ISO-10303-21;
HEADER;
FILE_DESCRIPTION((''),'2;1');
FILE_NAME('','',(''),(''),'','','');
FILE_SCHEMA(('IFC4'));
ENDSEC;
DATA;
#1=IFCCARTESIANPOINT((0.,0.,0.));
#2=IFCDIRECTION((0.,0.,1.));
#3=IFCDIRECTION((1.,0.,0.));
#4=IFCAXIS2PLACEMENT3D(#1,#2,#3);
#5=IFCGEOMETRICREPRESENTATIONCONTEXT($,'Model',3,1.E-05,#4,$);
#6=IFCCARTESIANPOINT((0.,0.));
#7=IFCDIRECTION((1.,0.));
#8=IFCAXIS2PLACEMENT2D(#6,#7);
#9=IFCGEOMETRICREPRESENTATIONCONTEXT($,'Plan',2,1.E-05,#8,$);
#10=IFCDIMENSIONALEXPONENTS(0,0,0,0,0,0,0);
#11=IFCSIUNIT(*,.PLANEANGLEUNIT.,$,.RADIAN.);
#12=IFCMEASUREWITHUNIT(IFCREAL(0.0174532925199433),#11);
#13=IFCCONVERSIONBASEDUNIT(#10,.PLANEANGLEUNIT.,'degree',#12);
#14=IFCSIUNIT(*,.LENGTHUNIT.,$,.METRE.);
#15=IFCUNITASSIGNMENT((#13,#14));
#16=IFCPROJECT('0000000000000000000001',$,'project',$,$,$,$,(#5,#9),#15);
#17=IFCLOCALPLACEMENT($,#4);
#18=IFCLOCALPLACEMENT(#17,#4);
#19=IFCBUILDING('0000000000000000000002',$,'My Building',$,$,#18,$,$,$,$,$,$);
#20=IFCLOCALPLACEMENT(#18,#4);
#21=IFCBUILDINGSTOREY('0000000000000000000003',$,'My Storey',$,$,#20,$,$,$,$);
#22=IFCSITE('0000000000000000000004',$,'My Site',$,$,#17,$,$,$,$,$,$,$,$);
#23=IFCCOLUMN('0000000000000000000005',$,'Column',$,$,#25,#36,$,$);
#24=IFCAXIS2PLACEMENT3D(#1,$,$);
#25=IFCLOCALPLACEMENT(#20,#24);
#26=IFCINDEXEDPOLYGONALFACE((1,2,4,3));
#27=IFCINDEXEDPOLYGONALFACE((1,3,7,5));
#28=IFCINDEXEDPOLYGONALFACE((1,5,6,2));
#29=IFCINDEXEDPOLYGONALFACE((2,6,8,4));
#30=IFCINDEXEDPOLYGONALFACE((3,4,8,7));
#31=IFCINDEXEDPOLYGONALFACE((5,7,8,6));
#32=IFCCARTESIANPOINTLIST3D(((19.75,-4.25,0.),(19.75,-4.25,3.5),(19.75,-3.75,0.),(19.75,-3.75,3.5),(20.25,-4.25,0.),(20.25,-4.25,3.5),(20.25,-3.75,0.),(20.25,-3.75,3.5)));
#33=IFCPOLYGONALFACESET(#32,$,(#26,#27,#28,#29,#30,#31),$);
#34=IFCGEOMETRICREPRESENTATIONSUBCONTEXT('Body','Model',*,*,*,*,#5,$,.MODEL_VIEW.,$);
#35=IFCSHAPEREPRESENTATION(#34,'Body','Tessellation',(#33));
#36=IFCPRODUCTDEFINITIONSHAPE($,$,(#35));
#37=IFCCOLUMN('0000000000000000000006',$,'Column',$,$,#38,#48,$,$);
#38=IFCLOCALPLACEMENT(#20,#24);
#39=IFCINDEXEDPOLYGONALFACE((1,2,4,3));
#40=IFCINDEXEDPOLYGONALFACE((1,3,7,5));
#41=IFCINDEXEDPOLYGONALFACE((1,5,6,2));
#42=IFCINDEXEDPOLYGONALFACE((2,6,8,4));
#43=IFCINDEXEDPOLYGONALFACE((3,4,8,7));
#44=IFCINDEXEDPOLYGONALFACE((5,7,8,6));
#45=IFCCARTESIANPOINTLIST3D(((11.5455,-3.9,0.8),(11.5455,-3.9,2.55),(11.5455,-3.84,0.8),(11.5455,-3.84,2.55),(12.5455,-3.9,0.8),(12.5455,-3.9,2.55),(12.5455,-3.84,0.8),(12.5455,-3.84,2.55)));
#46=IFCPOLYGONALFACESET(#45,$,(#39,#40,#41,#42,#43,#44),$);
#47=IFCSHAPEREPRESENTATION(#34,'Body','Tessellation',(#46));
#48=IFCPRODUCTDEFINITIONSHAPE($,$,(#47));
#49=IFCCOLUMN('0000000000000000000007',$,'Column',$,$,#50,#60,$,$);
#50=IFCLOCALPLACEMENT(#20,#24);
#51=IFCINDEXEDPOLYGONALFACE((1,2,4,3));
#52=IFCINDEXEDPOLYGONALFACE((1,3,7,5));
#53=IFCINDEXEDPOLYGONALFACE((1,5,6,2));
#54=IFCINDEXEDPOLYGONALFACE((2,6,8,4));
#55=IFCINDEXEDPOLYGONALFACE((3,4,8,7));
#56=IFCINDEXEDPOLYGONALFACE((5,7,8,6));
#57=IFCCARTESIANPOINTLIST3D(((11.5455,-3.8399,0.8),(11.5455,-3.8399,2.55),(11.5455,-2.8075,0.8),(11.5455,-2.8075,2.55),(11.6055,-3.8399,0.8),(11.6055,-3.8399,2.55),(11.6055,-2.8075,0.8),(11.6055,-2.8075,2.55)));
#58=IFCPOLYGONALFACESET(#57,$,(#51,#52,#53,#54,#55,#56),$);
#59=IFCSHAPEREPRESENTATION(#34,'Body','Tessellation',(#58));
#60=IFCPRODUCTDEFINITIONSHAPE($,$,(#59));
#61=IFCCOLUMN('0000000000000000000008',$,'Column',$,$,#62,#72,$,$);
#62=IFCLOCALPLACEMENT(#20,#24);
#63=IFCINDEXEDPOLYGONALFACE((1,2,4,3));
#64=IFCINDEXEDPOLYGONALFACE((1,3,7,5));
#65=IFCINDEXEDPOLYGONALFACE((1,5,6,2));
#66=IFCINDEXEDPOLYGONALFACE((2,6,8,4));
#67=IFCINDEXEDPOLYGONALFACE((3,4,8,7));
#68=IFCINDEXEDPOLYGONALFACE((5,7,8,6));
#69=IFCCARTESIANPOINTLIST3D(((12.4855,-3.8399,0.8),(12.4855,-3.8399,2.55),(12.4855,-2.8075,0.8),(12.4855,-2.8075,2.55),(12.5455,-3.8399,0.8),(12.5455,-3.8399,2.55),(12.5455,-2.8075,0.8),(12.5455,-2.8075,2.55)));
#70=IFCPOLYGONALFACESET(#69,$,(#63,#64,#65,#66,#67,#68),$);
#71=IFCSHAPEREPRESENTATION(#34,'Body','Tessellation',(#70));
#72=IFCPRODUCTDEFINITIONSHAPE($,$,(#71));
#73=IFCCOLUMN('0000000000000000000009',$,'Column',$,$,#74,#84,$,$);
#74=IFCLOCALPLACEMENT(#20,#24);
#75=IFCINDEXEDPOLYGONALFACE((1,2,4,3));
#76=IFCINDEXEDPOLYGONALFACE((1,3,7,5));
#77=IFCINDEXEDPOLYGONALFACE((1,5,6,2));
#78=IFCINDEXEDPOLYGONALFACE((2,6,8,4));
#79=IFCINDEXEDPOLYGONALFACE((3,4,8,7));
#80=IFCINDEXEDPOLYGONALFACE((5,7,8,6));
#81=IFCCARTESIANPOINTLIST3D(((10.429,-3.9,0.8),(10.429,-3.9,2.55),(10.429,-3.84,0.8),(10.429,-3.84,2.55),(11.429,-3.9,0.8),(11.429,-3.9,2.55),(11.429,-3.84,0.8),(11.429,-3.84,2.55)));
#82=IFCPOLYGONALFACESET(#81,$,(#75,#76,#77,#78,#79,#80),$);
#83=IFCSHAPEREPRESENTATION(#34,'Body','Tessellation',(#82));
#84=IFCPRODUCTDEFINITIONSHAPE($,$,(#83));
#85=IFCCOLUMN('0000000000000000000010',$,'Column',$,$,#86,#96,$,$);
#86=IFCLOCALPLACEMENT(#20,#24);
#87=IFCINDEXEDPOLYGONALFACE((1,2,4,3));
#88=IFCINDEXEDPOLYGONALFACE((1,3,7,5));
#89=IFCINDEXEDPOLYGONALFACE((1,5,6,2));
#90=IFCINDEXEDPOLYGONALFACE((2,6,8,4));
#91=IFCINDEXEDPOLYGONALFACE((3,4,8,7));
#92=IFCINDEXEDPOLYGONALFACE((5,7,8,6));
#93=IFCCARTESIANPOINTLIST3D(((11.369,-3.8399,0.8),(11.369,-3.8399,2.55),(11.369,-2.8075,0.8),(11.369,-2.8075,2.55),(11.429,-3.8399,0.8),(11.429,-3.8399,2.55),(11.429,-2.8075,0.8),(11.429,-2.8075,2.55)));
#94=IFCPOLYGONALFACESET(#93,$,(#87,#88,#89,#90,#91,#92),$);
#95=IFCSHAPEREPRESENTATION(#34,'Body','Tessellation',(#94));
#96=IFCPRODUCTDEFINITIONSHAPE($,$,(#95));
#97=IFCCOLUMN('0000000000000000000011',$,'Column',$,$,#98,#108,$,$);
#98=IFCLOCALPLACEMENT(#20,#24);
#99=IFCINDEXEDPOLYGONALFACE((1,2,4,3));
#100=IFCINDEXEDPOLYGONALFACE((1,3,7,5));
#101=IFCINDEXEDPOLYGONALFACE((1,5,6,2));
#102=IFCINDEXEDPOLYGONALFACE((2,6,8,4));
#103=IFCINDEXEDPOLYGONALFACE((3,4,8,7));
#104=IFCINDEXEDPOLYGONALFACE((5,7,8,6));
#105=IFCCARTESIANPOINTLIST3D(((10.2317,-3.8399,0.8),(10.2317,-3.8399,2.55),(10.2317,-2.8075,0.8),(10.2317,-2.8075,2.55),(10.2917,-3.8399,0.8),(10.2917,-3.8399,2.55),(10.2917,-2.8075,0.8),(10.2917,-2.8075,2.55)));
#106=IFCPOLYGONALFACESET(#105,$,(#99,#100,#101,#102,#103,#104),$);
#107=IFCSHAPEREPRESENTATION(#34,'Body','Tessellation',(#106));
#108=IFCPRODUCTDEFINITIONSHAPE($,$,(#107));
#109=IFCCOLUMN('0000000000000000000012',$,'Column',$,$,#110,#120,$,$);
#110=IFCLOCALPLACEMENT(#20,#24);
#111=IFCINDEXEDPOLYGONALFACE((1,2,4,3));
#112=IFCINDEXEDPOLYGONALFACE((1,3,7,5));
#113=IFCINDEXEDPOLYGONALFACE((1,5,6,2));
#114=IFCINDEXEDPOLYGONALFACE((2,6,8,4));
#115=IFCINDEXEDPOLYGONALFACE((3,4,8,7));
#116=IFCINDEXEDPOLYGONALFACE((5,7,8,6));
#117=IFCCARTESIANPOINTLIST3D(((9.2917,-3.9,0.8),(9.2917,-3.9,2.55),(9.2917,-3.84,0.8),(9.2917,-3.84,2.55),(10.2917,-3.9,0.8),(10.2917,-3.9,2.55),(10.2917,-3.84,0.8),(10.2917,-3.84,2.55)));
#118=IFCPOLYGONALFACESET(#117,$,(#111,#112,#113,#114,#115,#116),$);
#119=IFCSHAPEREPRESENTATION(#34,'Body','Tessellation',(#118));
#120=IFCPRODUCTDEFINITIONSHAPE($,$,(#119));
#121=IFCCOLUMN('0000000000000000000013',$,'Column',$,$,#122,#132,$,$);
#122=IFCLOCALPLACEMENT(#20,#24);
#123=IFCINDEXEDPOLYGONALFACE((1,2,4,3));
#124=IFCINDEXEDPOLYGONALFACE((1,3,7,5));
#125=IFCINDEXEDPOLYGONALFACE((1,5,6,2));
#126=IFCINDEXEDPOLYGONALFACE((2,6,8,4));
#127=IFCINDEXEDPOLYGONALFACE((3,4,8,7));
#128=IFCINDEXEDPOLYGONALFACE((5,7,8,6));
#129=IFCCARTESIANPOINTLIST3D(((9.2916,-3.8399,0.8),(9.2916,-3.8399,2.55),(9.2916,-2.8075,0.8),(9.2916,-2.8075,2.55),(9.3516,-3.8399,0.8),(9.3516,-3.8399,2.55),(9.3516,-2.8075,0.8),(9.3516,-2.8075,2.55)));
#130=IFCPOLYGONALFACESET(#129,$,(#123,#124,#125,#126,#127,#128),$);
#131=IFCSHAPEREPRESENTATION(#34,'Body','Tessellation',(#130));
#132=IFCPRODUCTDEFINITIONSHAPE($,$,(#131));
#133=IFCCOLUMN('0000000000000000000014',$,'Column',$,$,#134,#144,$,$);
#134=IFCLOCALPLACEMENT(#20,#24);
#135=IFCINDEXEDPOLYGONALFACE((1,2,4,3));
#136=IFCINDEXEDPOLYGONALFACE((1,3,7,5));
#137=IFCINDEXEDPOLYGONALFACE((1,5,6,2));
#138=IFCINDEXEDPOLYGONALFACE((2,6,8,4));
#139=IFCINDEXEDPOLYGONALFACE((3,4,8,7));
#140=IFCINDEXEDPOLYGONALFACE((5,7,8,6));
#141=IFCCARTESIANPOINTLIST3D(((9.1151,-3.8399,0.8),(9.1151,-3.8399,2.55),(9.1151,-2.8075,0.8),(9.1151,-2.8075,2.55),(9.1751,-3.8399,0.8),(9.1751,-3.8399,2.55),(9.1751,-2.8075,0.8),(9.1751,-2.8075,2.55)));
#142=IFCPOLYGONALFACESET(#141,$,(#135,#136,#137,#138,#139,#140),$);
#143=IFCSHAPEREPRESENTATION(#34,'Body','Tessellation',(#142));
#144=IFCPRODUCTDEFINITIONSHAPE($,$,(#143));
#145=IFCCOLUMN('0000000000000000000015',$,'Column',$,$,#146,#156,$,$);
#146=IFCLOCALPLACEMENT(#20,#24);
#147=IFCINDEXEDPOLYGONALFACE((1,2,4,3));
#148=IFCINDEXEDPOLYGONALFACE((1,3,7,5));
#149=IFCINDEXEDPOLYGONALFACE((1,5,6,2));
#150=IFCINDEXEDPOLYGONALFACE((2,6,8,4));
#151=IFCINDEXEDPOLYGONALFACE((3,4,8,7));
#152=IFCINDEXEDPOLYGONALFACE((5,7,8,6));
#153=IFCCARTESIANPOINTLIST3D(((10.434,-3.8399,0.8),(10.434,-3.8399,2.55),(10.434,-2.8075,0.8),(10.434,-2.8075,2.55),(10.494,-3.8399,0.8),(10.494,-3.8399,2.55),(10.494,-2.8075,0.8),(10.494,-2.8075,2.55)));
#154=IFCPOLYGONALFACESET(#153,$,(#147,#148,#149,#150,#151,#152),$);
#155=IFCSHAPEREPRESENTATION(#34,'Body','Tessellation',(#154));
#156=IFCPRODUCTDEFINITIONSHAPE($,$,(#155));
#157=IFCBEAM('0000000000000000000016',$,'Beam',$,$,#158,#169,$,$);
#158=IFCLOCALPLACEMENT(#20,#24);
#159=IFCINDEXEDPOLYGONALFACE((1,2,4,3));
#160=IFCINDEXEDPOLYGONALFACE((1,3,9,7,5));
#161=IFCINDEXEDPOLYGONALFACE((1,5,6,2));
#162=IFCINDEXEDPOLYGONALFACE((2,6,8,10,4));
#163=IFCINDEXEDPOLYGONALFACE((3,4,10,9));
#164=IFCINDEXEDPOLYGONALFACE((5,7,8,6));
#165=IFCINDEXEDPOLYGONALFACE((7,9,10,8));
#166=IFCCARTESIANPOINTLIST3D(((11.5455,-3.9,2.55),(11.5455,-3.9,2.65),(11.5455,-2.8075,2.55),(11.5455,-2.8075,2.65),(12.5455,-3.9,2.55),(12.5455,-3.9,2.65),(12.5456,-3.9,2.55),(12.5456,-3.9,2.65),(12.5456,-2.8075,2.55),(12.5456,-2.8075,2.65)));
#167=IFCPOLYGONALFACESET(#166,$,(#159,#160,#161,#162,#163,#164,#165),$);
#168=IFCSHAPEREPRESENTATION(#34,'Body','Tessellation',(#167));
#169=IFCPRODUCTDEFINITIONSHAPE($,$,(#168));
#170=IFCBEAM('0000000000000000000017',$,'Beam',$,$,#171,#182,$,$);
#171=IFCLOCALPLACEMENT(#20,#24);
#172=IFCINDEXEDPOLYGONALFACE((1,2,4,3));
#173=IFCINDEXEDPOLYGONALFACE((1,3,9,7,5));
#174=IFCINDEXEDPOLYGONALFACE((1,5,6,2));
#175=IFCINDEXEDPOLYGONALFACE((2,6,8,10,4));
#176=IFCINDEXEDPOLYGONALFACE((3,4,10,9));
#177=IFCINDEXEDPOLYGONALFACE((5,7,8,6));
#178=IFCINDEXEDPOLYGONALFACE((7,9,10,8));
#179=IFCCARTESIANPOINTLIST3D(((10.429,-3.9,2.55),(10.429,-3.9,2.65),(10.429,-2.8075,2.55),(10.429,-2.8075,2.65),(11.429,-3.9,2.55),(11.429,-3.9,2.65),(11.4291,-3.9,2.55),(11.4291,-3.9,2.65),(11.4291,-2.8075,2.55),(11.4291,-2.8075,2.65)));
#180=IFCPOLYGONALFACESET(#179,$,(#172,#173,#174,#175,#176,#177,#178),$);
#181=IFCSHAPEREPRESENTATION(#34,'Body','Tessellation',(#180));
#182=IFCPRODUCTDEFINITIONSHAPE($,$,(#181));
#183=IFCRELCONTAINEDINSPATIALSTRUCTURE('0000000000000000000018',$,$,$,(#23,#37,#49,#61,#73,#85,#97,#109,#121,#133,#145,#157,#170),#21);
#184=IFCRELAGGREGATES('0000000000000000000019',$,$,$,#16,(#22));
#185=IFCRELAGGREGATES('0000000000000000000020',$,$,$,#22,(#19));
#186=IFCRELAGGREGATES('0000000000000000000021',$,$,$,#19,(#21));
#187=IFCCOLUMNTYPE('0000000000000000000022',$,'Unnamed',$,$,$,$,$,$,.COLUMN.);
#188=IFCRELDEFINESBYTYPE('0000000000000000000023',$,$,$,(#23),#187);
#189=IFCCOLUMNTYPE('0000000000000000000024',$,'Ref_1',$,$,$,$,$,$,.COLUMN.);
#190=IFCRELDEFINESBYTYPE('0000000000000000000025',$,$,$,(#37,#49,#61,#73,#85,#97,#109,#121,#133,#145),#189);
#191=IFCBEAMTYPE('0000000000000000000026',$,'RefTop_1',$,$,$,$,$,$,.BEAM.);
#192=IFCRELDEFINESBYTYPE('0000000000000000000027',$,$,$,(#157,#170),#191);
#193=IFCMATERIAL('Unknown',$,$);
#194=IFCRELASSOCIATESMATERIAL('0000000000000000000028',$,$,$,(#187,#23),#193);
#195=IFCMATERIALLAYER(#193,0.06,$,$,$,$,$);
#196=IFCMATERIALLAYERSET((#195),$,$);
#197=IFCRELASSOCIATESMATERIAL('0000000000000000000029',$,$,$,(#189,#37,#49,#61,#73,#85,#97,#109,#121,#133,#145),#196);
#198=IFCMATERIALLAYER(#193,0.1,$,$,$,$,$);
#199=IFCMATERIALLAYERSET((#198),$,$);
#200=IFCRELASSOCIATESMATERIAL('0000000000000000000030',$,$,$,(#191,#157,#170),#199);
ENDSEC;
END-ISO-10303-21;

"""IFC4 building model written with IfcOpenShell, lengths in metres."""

from ifc_helpers import new_model, entity, si_unit, converted_unit, frame, origin_with_axes, origin_2d_with_axis, place, context, subcontext, project, spatial, line, indexed_curve, rectangle, outline, extrude, material, layer, layer_set, layer_usage, material_profile, profile_set, profile_usage, type_object, element, save


model = new_model("IFC4")

# Units and contexts
model_context = context("Model", 3, precision=1e-05, world=origin_with_axes())
plan_context = context("Plan", 2, precision=1e-05, world=origin_2d_with_axis())
body_context_1 = subcontext(model_context, "Body", "Model", "MODEL_VIEW")
ifc_project = project(units=[converted_unit("PLANEANGLEUNIT", "degree", entity("IfcReal", 0.0174532925199433), si_unit("PLANEANGLEUNIT", "RADIAN"), dimensions=[0, 0, 0, 0, 0, 0, 0]), si_unit("LENGTHUNIT", "METRE")], contexts=[model_context, plan_context])

# Site, building, storey
site_placement = place(None, origin_with_axes())
site = spatial("IfcSite", under=ifc_project, at=site_placement, Name="My Site")
building_placement = place(site_placement, origin_with_axes())
building = spatial("IfcBuilding", under=site, at=building_placement, Name="My Building")
storey_placement = place(building_placement, origin_with_axes())
storey = spatial("IfcBuildingStorey", under=building, at=storey_placement, Name="My Storey")

# Columns
ifc_material = material(Name="Unknown")
ifc_material_profile = material_profile(ifc_material, rectangle(XDim=0.5, YDim=0.5))
ifc_profile_set = profile_set([ifc_material_profile])
ifc_profile_usage = profile_usage(ifc_profile_set, cardinal=5)
column_type_1 = type_object("IfcColumnType", Name="Unnamed", PredefinedType="COLUMN", material=ifc_profile_set)
column_1_placement = place(storey_placement, frame((20.0, -4.0, 0.0), z_axis=(0.0, 0.0, 1.0), x_axis=(1.0, 0.0, 0.0)))
element("IfcColumn", 1, at=column_1_placement, inside=storey, type_object=column_type_1, material=ifc_profile_usage, Name="Column", context=body_context_1, shape_type="SweptSolid", body=[
    extrude(rectangle(XDim=0.5, YDim=0.5), origin_with_axes(), (0.0, 0.0, 1.0), 3.5),
])
ifc_layer_1 = layer(ifc_material, 0.06)
ifc_layer_set_1 = layer_set([ifc_layer_1])
ifc_layer_usage_1 = layer_usage(ifc_layer_set_1, "AXIS2", "POSITIVE", 0.0)
column_type_2 = type_object("IfcColumnType", Name="Ref_1", PredefinedType="COLUMN", material=ifc_layer_set_1)
column_2_placement = place(storey_placement, frame((11.5455, -3.9, 0.8), z_axis=(0.0, 0.0, 1.0), x_axis=(1.0, 0.0, 0.0)))
element("IfcColumn", 2, at=column_2_placement, inside=storey, type_object=column_type_2, material=ifc_layer_usage_1, Name="Column", context=body_context_1, shape_type="SweptSolid", body=[
    extrude(outline(indexed_curve([(0.0, 0.0), (0.0, 0.06), (1.0, 0.06), (1.0, 0.0)], segments=[line(1, 2, 3, 4, 1)])), origin_with_axes(), (0.0, 0.0, 1.0), 1.75),
])
ifc_layer_usage_2 = layer_usage(ifc_layer_set_1, "AXIS2", "POSITIVE", 0.0)
column_3_placement = place(storey_placement, frame((11.5455, -2.8075, 0.8), z_axis=(0.0, 0.0, 1.0), x_axis=(0.0, -1.0, 0.0)))
element("IfcColumn", 3, at=column_3_placement, inside=storey, type_object=column_type_2, material=ifc_layer_usage_2, Name="Column", context=body_context_1, shape_type="SweptSolid", body=[
    extrude(outline(indexed_curve([(0.0, 0.0), (0.0, 0.06), (1.0325, 0.06), (1.0325, 0.0)], segments=[line(1, 2, 3, 4, 1)])), origin_with_axes(), (0.0, 0.0, 1.0), 1.75),
])
ifc_layer_usage_3 = layer_usage(ifc_layer_set_1, "AXIS2", "POSITIVE", 0.0)
column_4_placement = place(storey_placement, frame((12.4855, -2.8075, 0.8), z_axis=(0.0, 0.0, 1.0), x_axis=(0.0, -1.0, 0.0)))
element("IfcColumn", 4, at=column_4_placement, inside=storey, type_object=column_type_2, material=ifc_layer_usage_3, Name="Column", context=body_context_1, shape_type="SweptSolid", body=[
    extrude(outline(indexed_curve([(0.0, 0.0), (0.0, 0.06), (1.0325, 0.06), (1.0325, 0.0)], segments=[line(1, 2, 3, 4, 1)])), origin_with_axes(), (0.0, 0.0, 1.0), 1.75),
])
ifc_layer_usage_4 = layer_usage(ifc_layer_set_1, "AXIS2", "POSITIVE", 0.0)
column_5_placement = place(storey_placement, frame((10.429, -3.9, 0.8), z_axis=(0.0, 0.0, 1.0), x_axis=(1.0, 0.0, 0.0)))
element("IfcColumn", 5, at=column_5_placement, inside=storey, type_object=column_type_2, material=ifc_layer_usage_4, Name="Column", context=body_context_1, shape_type="SweptSolid", body=[
    extrude(outline(indexed_curve([(0.0, 0.0), (0.0, 0.06), (1.0, 0.06), (1.0, 0.0)], segments=[line(1, 2, 3, 4, 1)])), origin_with_axes(), (0.0, 0.0, 1.0), 1.75),
])
ifc_layer_usage_5 = layer_usage(ifc_layer_set_1, "AXIS2", "POSITIVE", 0.0)
column_6_placement = place(storey_placement, frame((11.369, -2.8075, 0.8), z_axis=(0.0, 0.0, 1.0), x_axis=(0.0, -1.0, 0.0)))
element("IfcColumn", 6, at=column_6_placement, inside=storey, type_object=column_type_2, material=ifc_layer_usage_5, Name="Column", context=body_context_1, shape_type="SweptSolid", body=[
    extrude(outline(indexed_curve([(0.0, 0.0), (0.0, 0.06), (1.0325, 0.06), (1.0325, 0.0)], segments=[line(1, 2, 3, 4, 1)])), origin_with_axes(), (0.0, 0.0, 1.0), 1.75),
])
ifc_layer_usage_6 = layer_usage(ifc_layer_set_1, "AXIS2", "POSITIVE", 0.0)
column_7_placement = place(storey_placement, frame((10.2317, -2.8075, 0.8), z_axis=(0.0, 0.0, 1.0), x_axis=(0.0, -1.0, 0.0)))
element("IfcColumn", 7, at=column_7_placement, inside=storey, type_object=column_type_2, material=ifc_layer_usage_6, Name="Column", context=body_context_1, shape_type="SweptSolid", body=[
    extrude(outline(indexed_curve([(0.0, 0.0), (0.0, 0.06), (1.0325, 0.06), (1.0325, 0.0)], segments=[line(1, 2, 3, 4, 1)])), origin_with_axes(), (0.0, 0.0, 1.0), 1.75),
])
ifc_layer_usage_7 = layer_usage(ifc_layer_set_1, "AXIS2", "POSITIVE", 0.0)
column_8_placement = place(storey_placement, frame((9.2917, -3.9, 0.8), z_axis=(0.0, 0.0, 1.0), x_axis=(1.0, 0.0, 0.0)))
element("IfcColumn", 8, at=column_8_placement, inside=storey, type_object=column_type_2, material=ifc_layer_usage_7, Name="Column", context=body_context_1, shape_type="SweptSolid", body=[
    extrude(outline(indexed_curve([(0.0, 0.0), (0.0, 0.06), (1.0, 0.06), (1.0, 0.0)], segments=[line(1, 2, 3, 4, 1)])), origin_with_axes(), (0.0, 0.0, 1.0), 1.75),
])
ifc_layer_usage_8 = layer_usage(ifc_layer_set_1, "AXIS2", "POSITIVE", 0.0)
column_9_placement = place(storey_placement, frame((9.2916, -2.8075, 0.8), z_axis=(0.0, 0.0, 1.0), x_axis=(0.0, -1.0, 0.0)))
element("IfcColumn", 9, at=column_9_placement, inside=storey, type_object=column_type_2, material=ifc_layer_usage_8, Name="Column", context=body_context_1, shape_type="SweptSolid", body=[
    extrude(outline(indexed_curve([(0.0, 0.0), (0.0, 0.06), (1.0325, 0.06), (1.0325, 0.0)], segments=[line(1, 2, 3, 4, 1)])), origin_with_axes(), (0.0, 0.0, 1.0), 1.75),
])
ifc_layer_usage_9 = layer_usage(ifc_layer_set_1, "AXIS2", "POSITIVE", 0.0)
column_10_placement = place(storey_placement, frame((9.1151, -2.8075, 0.8), z_axis=(0.0, 0.0, 1.0), x_axis=(0.0, -1.0, 0.0)))
element("IfcColumn", 10, at=column_10_placement, inside=storey, type_object=column_type_2, material=ifc_layer_usage_9, Name="Column", context=body_context_1, shape_type="SweptSolid", body=[
    extrude(outline(indexed_curve([(0.0, 0.0), (0.0, 0.06), (1.0325, 0.06), (1.0325, 0.0)], segments=[line(1, 2, 3, 4, 1)])), origin_with_axes(), (0.0, 0.0, 1.0), 1.75),
])
ifc_layer_usage_10 = layer_usage(ifc_layer_set_1, "AXIS2", "POSITIVE", 0.0)
column_11_placement = place(storey_placement, frame((10.434, -2.8075, 0.8), z_axis=(0.0, 0.0, 1.0), x_axis=(0.000001, -1.0, 0.0)))
element("IfcColumn", 11, at=column_11_placement, inside=storey, type_object=column_type_2, material=ifc_layer_usage_10, Name="Column", context=body_context_1, shape_type="SweptSolid", body=[
    extrude(outline(indexed_curve([(0.0, 0.0), (0.0, 0.06), (1.0325, 0.06), (1.0325, 0.0)], segments=[line(1, 2, 3, 4, 1)])), origin_with_axes(), (0.0, 0.0, 1.0), 1.75),
])

# Beams
ifc_layer_2 = layer(ifc_material, 0.1)
ifc_layer_set_2 = layer_set([ifc_layer_2])
ifc_layer_usage_11 = layer_usage(ifc_layer_set_2, "AXIS3", "POSITIVE", -0.1)
beam_type_1 = type_object("IfcBeamType", Name="RefTop_1", PredefinedType="BEAM", material=ifc_layer_set_2)
beam_1_placement = place(storey_placement, frame((12.5455, -3.9, 2.65), z_axis=(0.0, 0.0, 1.0), x_axis=(1.0, 0.0, 0.0)))
element("IfcBeam", 12, at=beam_1_placement, inside=storey, type_object=beam_type_1, material=ifc_layer_usage_11, Name="Beam", context=body_context_1, shape_type="SweptSolid", body=[
    extrude(outline(indexed_curve([(0.0, 0.0), (-1.0, 0.0), (-1.0, 1.0925), (0.0001, 1.0925), (0.0001, 0.0), (0.0, 0.0)])), frame((0.0, 0.0, -0.1), z_axis=(0.0, 0.0, 1.0), x_axis=(1.0, 0.0, 0.0)), (0.0, 0.0, 1.0), 0.1),
])
ifc_layer_usage_12 = layer_usage(ifc_layer_set_2, "AXIS3", "POSITIVE", -0.1)
beam_2_placement = place(storey_placement, frame((11.429, -3.9, 2.65), z_axis=(0.0, 0.0, 1.0), x_axis=(1.0, 0.0, 0.0)))
element("IfcBeam", 13, at=beam_2_placement, inside=storey, type_object=beam_type_1, material=ifc_layer_usage_12, Name="Beam", context=body_context_1, shape_type="SweptSolid", body=[
    extrude(outline(indexed_curve([(0.0, 0.0), (-1.0, 0.0), (-1.0, 1.0925), (0.0001, 1.0925), (0.0001, 0.0), (0.0, 0.0)])), frame((0.0, 0.0, -0.1), z_axis=(0.0, 0.0, 1.0), x_axis=(1.0, 0.0, 0.0)), (0.0, 0.0, 1.0), 0.1),
])

save(model, "model.ifc")
